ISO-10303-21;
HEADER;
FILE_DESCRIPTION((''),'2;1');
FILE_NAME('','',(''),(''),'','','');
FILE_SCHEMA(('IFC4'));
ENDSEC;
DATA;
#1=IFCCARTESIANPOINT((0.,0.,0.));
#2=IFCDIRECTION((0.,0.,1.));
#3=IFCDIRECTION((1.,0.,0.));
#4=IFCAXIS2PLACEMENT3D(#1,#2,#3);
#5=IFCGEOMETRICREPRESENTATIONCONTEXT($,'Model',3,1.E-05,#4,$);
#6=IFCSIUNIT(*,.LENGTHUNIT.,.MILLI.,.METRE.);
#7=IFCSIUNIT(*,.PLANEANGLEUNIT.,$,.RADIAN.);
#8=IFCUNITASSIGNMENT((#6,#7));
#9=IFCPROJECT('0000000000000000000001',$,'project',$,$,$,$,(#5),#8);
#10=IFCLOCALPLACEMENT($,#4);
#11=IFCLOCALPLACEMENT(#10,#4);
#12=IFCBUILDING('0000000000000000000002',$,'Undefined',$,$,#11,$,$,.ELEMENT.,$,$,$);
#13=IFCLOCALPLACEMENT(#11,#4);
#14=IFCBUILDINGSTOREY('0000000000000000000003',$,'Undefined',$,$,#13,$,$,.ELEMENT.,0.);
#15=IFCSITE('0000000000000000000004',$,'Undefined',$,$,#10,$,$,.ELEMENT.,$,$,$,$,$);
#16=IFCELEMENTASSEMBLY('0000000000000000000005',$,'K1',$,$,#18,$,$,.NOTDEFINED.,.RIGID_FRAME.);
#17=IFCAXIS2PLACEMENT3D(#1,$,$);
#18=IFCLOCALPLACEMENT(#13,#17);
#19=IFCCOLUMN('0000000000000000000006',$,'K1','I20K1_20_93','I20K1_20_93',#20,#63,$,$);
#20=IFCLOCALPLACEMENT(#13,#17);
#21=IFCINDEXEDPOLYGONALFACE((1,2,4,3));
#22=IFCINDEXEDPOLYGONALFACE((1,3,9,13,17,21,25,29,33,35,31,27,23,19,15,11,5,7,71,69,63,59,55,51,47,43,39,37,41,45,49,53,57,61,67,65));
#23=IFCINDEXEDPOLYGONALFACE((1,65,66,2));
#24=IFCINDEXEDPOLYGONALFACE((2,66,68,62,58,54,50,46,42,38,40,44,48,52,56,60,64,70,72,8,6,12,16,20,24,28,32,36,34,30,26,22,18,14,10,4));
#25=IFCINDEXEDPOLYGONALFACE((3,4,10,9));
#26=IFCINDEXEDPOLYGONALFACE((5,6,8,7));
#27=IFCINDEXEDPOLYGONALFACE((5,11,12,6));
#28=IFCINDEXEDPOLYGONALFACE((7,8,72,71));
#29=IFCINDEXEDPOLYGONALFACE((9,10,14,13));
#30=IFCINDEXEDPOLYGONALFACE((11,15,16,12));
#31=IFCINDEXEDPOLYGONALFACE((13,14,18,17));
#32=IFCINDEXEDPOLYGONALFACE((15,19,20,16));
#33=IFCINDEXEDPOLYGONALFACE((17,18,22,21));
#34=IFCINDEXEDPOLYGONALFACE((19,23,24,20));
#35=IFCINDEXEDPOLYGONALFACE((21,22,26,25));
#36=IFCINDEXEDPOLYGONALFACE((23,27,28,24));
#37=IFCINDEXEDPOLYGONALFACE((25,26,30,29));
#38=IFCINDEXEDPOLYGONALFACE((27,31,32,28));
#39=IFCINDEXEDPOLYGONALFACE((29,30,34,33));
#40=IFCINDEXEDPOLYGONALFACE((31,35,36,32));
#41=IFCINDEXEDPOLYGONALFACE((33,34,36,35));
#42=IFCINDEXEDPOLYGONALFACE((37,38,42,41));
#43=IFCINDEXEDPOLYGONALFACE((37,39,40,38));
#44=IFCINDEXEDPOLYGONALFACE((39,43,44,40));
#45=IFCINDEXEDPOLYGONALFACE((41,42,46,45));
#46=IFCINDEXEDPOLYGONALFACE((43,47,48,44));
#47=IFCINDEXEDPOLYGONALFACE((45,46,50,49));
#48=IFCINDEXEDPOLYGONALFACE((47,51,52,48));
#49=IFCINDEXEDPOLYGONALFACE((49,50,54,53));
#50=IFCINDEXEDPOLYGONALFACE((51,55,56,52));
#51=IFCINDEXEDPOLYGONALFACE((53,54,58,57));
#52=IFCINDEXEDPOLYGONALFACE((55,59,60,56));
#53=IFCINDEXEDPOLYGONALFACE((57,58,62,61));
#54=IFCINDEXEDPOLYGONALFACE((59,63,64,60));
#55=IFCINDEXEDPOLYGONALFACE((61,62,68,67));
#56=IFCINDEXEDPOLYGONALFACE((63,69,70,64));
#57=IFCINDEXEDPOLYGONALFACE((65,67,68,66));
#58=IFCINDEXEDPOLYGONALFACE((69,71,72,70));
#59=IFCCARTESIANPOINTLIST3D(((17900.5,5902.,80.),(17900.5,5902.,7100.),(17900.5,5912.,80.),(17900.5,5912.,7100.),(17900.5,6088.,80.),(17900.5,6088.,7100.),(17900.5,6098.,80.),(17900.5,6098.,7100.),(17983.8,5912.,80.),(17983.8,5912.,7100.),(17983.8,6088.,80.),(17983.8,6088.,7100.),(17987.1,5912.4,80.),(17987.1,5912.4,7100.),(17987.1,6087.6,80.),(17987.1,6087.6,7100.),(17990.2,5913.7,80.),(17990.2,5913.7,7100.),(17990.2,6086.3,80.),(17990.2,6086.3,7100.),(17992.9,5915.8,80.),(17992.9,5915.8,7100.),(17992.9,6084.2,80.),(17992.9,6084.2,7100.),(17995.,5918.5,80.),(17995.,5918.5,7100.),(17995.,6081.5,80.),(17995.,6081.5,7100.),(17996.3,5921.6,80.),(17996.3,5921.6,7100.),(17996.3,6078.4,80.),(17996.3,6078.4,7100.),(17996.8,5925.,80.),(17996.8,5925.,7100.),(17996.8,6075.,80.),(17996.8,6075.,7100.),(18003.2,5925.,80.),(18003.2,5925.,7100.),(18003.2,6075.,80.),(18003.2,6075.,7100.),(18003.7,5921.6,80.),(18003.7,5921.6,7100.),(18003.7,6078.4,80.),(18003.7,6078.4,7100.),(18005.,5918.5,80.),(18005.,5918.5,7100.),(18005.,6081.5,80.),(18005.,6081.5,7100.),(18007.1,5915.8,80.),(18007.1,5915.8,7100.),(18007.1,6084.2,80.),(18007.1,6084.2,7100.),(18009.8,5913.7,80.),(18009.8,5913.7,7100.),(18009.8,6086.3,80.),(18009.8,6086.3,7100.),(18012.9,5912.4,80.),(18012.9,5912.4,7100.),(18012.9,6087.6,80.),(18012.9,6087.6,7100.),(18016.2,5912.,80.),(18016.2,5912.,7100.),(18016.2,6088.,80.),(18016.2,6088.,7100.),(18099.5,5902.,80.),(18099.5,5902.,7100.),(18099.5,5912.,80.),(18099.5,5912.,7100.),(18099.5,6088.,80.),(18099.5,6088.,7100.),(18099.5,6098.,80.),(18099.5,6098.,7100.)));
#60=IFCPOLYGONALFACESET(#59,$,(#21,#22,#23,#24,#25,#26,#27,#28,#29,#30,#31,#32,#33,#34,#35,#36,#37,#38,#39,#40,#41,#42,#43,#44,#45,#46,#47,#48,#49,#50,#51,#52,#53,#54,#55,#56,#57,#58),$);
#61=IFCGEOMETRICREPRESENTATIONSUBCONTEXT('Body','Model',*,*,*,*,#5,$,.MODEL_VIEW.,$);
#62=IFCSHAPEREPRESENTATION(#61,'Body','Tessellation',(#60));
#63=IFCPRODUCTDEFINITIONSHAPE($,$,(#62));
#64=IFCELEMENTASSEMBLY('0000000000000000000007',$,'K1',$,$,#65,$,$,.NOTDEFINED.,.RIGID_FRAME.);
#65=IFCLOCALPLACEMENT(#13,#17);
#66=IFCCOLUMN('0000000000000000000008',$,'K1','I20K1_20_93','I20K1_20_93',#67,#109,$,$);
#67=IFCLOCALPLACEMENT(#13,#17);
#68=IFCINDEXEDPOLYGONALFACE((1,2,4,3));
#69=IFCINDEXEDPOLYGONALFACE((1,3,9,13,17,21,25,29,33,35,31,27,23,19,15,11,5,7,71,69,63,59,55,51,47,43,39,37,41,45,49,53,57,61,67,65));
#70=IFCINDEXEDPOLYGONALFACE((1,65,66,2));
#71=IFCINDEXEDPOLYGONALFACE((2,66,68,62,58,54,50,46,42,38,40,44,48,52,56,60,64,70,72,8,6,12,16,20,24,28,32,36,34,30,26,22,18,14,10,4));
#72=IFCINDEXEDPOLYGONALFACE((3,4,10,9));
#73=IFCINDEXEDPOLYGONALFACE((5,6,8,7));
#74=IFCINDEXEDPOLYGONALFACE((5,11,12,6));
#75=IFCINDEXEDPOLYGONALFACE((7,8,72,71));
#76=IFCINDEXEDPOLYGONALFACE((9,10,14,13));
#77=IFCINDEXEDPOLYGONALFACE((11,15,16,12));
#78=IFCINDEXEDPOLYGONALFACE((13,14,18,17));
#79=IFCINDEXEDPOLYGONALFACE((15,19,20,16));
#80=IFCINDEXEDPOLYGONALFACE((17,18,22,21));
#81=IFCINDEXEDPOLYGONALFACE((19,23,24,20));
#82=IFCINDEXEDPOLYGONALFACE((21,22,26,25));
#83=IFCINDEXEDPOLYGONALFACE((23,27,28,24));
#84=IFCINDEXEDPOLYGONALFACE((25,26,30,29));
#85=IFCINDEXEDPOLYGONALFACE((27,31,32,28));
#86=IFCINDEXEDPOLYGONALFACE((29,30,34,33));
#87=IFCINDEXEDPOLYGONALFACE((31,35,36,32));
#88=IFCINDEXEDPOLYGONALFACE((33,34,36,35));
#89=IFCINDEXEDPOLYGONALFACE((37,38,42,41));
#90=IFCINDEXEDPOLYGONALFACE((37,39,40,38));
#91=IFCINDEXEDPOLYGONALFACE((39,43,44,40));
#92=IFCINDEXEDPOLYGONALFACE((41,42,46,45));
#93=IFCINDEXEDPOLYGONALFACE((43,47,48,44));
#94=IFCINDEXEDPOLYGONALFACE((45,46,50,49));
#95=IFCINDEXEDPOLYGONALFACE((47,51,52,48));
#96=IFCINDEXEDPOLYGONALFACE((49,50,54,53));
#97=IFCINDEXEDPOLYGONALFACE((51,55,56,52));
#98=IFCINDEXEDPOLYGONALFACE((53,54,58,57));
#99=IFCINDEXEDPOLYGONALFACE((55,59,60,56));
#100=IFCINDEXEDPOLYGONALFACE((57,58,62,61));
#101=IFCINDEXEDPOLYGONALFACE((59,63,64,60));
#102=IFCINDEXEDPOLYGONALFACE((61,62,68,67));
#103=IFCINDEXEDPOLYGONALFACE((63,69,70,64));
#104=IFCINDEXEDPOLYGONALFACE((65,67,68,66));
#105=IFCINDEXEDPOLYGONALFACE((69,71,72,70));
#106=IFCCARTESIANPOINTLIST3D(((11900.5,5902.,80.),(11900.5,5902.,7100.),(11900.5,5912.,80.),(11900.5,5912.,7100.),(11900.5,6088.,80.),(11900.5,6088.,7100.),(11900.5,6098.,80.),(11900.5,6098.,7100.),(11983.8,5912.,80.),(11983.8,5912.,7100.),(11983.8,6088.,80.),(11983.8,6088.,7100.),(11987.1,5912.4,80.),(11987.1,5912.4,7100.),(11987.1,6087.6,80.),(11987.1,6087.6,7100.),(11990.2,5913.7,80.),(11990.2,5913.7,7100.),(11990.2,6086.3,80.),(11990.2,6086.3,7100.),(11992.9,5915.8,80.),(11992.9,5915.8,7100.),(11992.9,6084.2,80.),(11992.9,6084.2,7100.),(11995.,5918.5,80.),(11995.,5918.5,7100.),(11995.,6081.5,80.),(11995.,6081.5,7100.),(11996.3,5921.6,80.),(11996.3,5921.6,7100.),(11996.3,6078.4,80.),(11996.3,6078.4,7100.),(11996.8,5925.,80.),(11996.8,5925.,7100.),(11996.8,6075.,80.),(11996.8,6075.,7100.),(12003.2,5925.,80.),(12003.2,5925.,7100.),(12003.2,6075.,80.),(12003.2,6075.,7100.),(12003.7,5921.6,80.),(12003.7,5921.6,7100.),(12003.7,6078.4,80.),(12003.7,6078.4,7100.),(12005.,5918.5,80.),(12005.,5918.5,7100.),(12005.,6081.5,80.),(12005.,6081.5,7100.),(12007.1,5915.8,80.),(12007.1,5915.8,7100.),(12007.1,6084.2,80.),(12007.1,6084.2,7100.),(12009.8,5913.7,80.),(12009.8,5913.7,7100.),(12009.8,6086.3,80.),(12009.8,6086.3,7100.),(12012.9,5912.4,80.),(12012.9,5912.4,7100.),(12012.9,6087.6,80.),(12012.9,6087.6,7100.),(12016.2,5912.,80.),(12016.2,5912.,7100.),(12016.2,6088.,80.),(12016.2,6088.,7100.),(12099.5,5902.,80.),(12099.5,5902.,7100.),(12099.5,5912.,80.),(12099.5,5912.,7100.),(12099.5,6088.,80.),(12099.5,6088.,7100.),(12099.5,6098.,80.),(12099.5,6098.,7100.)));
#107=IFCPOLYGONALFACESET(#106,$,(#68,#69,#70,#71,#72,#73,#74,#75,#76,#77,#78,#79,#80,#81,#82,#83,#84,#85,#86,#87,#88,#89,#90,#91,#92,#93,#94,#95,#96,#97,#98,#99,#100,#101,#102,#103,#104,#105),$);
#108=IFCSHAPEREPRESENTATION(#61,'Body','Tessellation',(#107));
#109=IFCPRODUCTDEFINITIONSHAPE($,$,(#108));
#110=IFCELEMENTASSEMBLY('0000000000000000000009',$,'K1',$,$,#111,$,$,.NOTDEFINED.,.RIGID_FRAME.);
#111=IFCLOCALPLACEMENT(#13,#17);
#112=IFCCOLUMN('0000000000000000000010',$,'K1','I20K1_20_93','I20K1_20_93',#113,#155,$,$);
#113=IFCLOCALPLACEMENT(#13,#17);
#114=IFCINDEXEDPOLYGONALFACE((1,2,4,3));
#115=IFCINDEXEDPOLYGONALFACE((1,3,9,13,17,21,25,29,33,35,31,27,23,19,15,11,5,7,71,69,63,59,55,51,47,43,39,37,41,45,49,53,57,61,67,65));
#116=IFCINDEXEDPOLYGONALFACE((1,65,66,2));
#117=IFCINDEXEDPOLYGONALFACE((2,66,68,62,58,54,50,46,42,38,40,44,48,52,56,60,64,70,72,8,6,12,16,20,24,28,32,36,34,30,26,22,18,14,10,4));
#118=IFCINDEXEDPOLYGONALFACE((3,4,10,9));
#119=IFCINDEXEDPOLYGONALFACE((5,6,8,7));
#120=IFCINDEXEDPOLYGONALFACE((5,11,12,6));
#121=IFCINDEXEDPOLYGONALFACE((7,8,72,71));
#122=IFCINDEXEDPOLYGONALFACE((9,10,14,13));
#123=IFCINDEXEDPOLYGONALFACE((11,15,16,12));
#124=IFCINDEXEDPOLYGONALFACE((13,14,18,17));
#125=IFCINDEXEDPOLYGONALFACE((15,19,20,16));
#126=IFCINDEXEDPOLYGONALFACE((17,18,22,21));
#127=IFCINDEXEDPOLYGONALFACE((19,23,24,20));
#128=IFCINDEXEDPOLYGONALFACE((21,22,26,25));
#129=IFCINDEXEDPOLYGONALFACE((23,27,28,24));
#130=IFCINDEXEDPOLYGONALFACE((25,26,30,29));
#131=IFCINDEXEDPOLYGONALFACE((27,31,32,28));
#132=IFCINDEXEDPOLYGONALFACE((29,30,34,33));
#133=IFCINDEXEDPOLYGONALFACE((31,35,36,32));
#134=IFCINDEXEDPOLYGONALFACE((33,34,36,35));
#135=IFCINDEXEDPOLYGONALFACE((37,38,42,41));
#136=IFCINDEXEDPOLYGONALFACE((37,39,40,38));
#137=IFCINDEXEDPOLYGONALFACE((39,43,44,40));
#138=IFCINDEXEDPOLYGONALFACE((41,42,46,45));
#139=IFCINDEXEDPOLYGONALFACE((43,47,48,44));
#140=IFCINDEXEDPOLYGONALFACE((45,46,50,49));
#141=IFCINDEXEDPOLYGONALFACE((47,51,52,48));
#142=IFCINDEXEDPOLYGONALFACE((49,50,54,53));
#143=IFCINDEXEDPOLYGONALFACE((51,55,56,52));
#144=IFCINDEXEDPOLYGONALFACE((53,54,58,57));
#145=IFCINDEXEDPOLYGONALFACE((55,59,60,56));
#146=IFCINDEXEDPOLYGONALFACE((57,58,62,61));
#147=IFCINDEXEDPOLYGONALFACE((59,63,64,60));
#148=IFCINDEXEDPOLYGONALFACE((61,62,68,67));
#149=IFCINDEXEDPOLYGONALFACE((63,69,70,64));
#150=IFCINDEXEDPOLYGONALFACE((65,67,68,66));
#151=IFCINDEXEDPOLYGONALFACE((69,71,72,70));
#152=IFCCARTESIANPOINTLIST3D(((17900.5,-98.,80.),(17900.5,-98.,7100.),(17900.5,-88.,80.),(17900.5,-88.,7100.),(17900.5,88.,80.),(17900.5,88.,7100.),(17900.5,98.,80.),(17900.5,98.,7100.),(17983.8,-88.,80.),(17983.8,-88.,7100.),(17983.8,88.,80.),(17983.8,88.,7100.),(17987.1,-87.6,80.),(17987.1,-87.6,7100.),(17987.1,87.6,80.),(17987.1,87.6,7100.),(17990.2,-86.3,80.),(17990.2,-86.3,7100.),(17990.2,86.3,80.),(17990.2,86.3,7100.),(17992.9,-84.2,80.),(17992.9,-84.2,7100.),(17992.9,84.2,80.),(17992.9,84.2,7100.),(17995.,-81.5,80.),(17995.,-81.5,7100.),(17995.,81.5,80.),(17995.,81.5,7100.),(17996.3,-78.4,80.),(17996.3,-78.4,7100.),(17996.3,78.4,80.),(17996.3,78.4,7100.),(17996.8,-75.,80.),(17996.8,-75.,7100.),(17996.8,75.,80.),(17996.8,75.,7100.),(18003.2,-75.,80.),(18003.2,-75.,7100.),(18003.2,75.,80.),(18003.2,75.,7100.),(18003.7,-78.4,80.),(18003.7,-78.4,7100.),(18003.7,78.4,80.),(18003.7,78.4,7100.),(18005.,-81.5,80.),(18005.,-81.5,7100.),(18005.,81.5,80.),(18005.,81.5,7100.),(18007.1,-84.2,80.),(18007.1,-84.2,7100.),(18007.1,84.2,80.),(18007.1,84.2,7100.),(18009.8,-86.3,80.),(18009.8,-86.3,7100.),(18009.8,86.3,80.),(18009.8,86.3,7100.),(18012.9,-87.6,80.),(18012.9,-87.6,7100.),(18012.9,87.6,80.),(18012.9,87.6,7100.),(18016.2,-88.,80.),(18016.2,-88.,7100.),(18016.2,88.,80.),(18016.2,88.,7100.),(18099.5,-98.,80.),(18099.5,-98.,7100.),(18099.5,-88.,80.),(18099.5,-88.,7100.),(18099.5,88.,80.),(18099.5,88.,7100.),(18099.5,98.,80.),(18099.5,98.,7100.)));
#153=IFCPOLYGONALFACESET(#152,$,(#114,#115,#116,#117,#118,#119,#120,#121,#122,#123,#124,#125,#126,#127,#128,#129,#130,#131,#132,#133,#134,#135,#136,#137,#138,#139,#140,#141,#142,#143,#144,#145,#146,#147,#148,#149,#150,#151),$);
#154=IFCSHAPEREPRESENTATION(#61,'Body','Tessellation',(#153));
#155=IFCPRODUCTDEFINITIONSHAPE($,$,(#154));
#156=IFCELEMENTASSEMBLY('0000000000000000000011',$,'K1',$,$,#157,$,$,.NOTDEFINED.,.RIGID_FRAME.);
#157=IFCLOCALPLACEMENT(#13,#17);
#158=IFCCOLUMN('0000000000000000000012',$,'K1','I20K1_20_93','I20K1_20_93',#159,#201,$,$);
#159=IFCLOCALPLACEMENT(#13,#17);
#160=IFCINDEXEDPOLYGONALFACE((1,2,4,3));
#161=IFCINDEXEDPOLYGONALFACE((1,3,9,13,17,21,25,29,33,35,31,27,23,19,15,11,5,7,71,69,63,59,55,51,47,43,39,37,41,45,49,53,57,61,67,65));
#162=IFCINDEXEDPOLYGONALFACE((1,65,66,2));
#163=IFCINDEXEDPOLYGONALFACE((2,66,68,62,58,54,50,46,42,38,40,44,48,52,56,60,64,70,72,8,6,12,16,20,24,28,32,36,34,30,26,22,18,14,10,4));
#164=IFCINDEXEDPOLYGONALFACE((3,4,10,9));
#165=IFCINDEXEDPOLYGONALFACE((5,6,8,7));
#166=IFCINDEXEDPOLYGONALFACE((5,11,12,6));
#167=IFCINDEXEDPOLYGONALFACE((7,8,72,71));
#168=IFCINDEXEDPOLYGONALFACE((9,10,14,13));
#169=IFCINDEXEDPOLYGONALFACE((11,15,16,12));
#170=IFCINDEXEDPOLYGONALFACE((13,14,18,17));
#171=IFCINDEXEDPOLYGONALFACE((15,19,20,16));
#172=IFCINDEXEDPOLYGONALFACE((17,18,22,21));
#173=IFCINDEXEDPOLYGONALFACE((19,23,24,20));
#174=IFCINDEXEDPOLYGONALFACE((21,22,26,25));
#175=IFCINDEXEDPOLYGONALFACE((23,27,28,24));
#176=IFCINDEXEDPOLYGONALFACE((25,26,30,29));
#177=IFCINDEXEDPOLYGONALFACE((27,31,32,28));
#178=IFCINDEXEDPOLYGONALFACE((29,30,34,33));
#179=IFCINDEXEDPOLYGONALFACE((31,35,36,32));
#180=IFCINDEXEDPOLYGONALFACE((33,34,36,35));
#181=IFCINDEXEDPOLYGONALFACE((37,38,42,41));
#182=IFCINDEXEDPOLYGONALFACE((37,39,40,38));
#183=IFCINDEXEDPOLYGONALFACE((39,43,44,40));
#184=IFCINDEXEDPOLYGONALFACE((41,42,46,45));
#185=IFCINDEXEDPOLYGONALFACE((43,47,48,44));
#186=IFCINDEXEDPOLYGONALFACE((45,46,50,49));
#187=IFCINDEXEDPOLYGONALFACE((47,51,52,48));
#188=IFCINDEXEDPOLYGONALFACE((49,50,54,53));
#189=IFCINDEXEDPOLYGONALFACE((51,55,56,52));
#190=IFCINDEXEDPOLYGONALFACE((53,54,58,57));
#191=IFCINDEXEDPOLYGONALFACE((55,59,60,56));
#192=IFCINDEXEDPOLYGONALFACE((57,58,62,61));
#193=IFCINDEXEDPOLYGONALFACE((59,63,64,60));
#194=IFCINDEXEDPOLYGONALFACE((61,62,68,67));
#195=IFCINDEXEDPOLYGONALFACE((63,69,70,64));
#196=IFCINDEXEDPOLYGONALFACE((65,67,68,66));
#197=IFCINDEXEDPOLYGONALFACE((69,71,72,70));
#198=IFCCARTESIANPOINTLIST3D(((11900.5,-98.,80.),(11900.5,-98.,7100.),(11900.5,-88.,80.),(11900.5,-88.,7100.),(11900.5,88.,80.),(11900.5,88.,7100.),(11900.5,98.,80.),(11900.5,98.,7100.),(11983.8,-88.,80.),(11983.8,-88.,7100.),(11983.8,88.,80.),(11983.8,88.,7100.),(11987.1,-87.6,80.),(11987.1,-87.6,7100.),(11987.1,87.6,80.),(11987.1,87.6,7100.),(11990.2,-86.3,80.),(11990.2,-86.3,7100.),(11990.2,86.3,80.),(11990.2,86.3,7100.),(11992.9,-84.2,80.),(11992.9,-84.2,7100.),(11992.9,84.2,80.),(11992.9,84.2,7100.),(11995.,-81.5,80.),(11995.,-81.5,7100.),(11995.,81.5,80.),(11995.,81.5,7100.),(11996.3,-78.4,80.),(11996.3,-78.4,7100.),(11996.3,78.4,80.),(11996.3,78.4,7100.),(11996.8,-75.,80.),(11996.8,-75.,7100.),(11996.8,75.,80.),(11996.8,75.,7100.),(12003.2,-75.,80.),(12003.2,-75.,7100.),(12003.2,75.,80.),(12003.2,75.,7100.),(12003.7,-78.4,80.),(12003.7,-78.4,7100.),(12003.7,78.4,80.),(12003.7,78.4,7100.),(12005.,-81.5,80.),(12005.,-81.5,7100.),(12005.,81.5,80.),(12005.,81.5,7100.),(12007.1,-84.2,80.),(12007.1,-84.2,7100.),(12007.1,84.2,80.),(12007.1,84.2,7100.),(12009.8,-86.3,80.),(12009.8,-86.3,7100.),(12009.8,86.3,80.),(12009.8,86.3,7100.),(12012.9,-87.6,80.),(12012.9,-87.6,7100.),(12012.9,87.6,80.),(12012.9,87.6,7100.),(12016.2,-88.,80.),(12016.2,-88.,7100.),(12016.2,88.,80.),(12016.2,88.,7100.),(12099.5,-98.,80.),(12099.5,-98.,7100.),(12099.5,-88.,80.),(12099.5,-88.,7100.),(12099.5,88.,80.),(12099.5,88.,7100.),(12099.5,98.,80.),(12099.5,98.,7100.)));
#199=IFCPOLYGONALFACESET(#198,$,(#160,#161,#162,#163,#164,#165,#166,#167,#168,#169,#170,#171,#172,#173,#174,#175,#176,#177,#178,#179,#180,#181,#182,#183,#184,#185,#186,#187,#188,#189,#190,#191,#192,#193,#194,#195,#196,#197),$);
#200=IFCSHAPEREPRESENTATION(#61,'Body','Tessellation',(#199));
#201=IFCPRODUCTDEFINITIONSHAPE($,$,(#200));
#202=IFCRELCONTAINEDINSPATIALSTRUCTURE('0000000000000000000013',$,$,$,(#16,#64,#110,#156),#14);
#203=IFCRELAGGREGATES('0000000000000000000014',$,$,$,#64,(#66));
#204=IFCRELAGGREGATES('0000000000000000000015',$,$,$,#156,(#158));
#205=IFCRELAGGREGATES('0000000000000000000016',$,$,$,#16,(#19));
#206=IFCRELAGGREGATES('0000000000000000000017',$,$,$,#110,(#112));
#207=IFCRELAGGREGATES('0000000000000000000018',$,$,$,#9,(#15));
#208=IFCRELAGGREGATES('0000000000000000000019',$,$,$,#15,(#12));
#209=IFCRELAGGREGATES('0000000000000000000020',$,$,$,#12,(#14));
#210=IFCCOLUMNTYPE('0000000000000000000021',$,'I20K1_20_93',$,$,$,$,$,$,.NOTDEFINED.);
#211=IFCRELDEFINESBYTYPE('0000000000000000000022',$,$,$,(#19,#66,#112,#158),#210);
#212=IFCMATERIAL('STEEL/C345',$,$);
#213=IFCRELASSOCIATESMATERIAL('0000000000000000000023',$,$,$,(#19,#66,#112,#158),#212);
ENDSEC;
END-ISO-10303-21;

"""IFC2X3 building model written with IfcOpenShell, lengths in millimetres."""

from ifc_helpers import new_model, si_unit, frame, origin_with_axes, origin_2d_with_axis, place, context, subcontext, project, spatial, i_section, extrude, material, type_object, element, aggregate, save


model = new_model("IFC2X3")

# Units and contexts
model_context = context("Model", 3, precision=1e-05, world=origin_with_axes())
body_context = subcontext(model_context, "Body", "Model", "MODEL_VIEW")
ifc_project = project(units=[si_unit("LENGTHUNIT", "METRE", prefix="MILLI"), si_unit("PLANEANGLEUNIT", "RADIAN")], contexts=[model_context])

# Site, building, storey
site_placement = place(None, origin_with_axes())
site = spatial("IfcSite", under=ifc_project, at=site_placement, Name="Undefined", CompositionType="ELEMENT")
building_placement = place(site_placement, origin_with_axes())
building = spatial("IfcBuilding", under=site, at=building_placement, Name="Undefined", CompositionType="ELEMENT")
storey_placement = place(building_placement, origin_with_axes())
storey = spatial("IfcBuildingStorey", under=building, at=storey_placement, Name="Undefined", CompositionType="ELEMENT", Elevation=0.0)

# Element assemblies, columns
assembly_1_placement = place(storey_placement, origin_with_axes())
assembly_1 = element("IfcElementAssembly", 1, at=assembly_1_placement, inside=storey, Name="K1", AssemblyPlace="NOTDEFINED", PredefinedType="RIGID_FRAME")
ifc_material_1 = material(Name="STEEL/C345")
column_type_1 = type_object("IfcColumnType", Name="I20K1_20_93", PredefinedType="NOTDEFINED")
column_1_placement = place(assembly_1_placement, frame((18000.0, 6000.0, 80.0), z_axis=(0.0, 0.0, 1.0), x_axis=(0.0, 1.0, 0.0)))
column_1 = element("IfcColumn", 2, at=column_1_placement, type_object=column_type_1, material=ifc_material_1, Name="K1", Description="I20K1_20_93", ObjectType="I20K1_20_93", context=body_context, shape_type="SweptSolid", body=[
    extrude(i_section(OverallWidth=199.0, OverallDepth=196.0, WebThickness=6.5, FlangeThickness=10.0, FilletRadius=13.0, at=origin_2d_with_axis()), frame((0.0, 0.0, 7020.0), z_axis=(0.0, 0.0, -1.0), x_axis=(0.0, 1.0, 0.0)), (0.0, 0.0, 1.0), 7020.0),
])
assembly_2_placement = place(storey_placement, origin_with_axes())
assembly_2 = element("IfcElementAssembly", 3, at=assembly_2_placement, inside=storey, Name="K1", AssemblyPlace="NOTDEFINED", PredefinedType="RIGID_FRAME")
column_2_placement = place(assembly_2_placement, frame((12000.0, 6000.0, 80.0), z_axis=(0.0, 0.0, 1.0), x_axis=(0.0, 1.0, 0.0)))
column_2 = element("IfcColumn", 4, at=column_2_placement, type_object=column_type_1, material=ifc_material_1, Name="K1", Description="I20K1_20_93", ObjectType="I20K1_20_93", context=body_context, shape_type="SweptSolid", body=[
    extrude(i_section(OverallWidth=199.0, OverallDepth=196.0, WebThickness=6.5, FlangeThickness=10.0, FilletRadius=13.0, at=origin_2d_with_axis()), frame((0.0, 0.0, 7020.0), z_axis=(0.0, 0.0, -1.0), x_axis=(0.0, 1.0, 0.0)), (0.0, 0.0, 1.0), 7020.0),
])
aggregate(assembly_2, [column_2])
assembly_3_placement = place(storey_placement, origin_with_axes())
assembly_3 = element("IfcElementAssembly", 5, at=assembly_3_placement, inside=storey, Name="K1", AssemblyPlace="NOTDEFINED", PredefinedType="RIGID_FRAME")
column_3_placement = place(assembly_3_placement, frame((18000.0, 0.0, 80.0), z_axis=(0.0, 0.0, 1.0), x_axis=(0.0, 1.0, 0.0)))
column_3 = element("IfcColumn", 6, at=column_3_placement, type_object=column_type_1, material=ifc_material_1, Name="K1", Description="I20K1_20_93", ObjectType="I20K1_20_93", context=body_context, shape_type="SweptSolid", body=[
    extrude(i_section(OverallWidth=199.0, OverallDepth=196.0, WebThickness=6.5, FlangeThickness=10.0, FilletRadius=13.0, at=origin_2d_with_axis()), frame((0.0, 0.0, 7020.0), z_axis=(0.0, 0.0, -1.0), x_axis=(0.0, 1.0, 0.0)), (0.0, 0.0, 1.0), 7020.0),
])
assembly_4_placement = place(storey_placement, origin_with_axes())
assembly_4 = element("IfcElementAssembly", 7, at=assembly_4_placement, inside=storey, Name="K1", AssemblyPlace="NOTDEFINED", PredefinedType="RIGID_FRAME")
column_4_placement = place(assembly_4_placement, frame((12000.0, 0.0, 80.0), z_axis=(0.0, 0.0, 1.0), x_axis=(0.0, 1.0, 0.0)))
column_4 = element("IfcColumn", 8, at=column_4_placement, type_object=column_type_1, material=ifc_material_1, Name="K1", Description="I20K1_20_93", ObjectType="I20K1_20_93", context=body_context, shape_type="SweptSolid", body=[
    extrude(i_section(OverallWidth=199.0, OverallDepth=196.0, WebThickness=6.5, FlangeThickness=10.0, FilletRadius=13.0, at=origin_2d_with_axis()), frame((0.0, 0.0, 7020.0), z_axis=(0.0, 0.0, -1.0), x_axis=(0.0, 1.0, 0.0)), (0.0, 0.0, 1.0), 7020.0),
])
aggregate(assembly_4, [column_4])

aggregate(assembly_1, [column_1])
aggregate(assembly_3, [column_3])

save(model, "model.ifc")
